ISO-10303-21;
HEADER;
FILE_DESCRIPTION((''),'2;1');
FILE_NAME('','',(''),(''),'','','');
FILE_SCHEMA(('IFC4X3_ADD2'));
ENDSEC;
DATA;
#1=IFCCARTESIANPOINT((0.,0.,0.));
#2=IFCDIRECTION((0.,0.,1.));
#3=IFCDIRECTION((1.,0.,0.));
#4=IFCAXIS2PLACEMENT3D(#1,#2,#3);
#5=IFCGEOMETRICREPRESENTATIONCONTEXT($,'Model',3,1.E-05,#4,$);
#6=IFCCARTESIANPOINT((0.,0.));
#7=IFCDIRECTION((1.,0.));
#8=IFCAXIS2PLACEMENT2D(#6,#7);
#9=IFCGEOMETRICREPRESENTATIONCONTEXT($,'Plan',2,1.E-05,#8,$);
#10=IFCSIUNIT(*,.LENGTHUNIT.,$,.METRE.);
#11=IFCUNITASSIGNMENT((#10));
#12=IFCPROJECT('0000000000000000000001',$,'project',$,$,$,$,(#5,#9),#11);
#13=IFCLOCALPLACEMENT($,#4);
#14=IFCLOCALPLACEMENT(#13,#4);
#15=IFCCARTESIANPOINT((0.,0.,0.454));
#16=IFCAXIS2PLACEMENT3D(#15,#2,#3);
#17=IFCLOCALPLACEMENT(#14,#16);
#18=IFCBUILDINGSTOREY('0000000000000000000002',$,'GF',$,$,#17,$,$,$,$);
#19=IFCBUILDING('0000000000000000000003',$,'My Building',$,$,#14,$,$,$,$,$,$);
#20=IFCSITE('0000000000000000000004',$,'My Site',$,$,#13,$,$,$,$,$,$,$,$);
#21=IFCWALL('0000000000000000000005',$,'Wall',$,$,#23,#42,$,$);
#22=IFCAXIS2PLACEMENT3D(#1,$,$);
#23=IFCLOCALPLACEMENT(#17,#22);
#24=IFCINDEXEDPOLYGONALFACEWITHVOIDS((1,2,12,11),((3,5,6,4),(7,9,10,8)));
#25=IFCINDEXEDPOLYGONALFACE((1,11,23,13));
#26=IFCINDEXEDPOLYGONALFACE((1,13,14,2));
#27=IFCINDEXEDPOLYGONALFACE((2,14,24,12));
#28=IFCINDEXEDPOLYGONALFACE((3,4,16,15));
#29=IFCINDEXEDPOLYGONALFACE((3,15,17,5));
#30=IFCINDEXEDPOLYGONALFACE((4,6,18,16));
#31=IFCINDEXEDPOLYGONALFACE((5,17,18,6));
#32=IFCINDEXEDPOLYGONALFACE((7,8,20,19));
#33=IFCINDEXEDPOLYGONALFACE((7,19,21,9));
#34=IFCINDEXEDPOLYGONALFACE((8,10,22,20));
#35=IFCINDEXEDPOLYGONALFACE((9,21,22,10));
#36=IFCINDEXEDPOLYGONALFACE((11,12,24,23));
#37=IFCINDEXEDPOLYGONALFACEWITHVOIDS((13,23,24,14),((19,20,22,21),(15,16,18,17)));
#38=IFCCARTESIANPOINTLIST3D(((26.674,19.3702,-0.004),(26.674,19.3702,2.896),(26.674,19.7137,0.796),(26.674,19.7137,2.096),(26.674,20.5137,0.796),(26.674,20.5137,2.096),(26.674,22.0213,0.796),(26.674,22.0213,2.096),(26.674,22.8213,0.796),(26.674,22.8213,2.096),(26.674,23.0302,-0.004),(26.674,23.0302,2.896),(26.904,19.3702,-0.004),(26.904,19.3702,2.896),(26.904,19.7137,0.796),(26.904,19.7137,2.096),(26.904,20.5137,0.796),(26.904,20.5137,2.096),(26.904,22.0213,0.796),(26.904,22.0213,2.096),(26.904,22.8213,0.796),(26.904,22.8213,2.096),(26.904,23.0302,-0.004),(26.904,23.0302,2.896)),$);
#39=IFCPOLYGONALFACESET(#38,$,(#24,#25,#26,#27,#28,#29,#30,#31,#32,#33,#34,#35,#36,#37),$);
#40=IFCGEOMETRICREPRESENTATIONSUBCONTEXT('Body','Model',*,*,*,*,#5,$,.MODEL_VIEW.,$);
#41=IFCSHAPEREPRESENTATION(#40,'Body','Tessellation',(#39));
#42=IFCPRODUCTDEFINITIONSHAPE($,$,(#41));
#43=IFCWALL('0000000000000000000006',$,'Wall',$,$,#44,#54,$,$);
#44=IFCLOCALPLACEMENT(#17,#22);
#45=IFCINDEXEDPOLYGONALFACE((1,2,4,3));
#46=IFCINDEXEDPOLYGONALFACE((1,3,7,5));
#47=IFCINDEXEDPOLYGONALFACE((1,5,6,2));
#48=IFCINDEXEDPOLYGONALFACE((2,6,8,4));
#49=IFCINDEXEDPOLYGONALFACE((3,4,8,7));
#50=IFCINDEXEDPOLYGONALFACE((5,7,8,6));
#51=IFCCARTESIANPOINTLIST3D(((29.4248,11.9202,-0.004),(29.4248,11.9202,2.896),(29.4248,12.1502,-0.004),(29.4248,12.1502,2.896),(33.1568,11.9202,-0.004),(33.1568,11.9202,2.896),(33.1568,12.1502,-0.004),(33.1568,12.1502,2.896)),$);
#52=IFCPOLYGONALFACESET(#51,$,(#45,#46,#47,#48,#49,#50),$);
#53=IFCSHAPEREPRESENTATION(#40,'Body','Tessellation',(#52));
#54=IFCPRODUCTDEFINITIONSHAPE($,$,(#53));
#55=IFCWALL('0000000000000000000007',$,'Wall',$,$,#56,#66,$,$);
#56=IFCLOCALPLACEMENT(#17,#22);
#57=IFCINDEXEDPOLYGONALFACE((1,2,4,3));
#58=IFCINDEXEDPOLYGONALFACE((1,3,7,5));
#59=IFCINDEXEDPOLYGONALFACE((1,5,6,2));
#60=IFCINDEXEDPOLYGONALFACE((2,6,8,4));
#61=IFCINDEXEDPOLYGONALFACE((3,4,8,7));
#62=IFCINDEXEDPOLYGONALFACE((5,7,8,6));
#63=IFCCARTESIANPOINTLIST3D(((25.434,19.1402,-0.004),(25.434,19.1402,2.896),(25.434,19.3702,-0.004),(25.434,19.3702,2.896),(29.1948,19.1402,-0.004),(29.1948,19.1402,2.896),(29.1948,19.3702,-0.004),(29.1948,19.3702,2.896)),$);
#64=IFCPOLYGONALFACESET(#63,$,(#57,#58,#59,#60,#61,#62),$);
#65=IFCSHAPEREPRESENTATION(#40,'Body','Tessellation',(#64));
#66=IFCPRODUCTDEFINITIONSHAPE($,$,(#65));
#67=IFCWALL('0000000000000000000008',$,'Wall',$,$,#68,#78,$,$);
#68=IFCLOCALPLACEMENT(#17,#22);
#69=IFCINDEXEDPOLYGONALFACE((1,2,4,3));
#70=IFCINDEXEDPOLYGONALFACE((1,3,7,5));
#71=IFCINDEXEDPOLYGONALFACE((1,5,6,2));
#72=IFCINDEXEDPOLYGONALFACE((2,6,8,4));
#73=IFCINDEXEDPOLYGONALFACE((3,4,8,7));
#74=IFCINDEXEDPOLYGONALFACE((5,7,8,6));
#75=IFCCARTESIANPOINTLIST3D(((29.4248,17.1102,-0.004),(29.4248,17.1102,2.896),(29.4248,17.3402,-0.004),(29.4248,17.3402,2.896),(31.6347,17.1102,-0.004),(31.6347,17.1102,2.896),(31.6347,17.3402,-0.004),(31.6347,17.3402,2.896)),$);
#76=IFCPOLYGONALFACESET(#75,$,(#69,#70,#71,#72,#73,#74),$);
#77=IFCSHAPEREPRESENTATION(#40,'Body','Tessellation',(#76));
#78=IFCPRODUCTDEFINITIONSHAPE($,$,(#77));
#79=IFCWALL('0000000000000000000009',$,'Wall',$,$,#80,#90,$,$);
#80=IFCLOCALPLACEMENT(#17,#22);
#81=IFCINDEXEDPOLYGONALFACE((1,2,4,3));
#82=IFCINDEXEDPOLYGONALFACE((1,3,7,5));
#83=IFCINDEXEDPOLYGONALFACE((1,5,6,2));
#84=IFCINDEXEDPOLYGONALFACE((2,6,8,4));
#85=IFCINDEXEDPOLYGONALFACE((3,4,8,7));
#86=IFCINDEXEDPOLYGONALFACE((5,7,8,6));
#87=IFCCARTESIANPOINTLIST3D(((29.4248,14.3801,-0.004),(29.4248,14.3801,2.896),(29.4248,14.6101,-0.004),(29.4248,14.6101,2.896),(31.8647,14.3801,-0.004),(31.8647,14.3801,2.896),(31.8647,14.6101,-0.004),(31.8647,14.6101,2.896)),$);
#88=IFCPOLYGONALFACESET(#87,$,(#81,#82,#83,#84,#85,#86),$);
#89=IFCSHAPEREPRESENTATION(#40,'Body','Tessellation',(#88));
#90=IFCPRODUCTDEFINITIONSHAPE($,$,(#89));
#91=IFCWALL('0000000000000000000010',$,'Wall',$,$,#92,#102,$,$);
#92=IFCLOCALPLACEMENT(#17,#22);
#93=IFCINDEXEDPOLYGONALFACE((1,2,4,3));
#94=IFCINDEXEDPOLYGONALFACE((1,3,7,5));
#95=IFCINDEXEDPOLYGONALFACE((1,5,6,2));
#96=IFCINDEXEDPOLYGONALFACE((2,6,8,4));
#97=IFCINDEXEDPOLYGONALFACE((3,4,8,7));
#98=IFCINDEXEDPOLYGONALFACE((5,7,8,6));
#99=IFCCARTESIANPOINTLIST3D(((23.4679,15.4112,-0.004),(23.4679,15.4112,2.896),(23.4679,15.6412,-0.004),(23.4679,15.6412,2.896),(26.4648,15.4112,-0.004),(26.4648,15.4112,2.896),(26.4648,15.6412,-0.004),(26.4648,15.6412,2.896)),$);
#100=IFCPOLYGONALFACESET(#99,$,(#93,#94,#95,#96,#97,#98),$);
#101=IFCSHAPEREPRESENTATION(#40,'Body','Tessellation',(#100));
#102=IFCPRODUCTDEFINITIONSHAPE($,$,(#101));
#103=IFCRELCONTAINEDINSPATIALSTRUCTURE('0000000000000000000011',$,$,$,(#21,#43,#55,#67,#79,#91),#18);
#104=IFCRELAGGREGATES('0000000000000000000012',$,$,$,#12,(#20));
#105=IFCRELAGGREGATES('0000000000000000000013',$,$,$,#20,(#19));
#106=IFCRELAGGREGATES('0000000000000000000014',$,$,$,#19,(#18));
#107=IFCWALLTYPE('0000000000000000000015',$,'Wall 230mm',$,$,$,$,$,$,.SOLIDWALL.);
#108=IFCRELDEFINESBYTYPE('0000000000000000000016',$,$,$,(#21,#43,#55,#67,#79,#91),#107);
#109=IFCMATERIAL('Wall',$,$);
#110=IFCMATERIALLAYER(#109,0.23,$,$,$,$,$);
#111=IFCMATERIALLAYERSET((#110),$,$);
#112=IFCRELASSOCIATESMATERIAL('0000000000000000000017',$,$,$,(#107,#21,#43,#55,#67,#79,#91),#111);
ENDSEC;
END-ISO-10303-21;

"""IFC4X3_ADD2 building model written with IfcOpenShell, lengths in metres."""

from ifc_helpers import new_model, si_unit, frame, origin_with_axes, origin_2d_with_axis, place, context, subcontext, project, spatial, line, indexed_curve, outline, extrude, source, transform, mapped, material, layer, layer_set, layer_usage, type_object, element, save


model = new_model("IFC4X3_ADD2")

# Units and contexts
model_context = context("Model", 3, precision=1e-05, world=origin_with_axes())
plan_context = context("Plan", 2, precision=1e-05, world=origin_2d_with_axis())
body_context_1 = subcontext(model_context, "Body", "Model", "MODEL_VIEW")
ifc_project = project(units=[si_unit("LENGTHUNIT", "METRE")], contexts=[model_context, plan_context])

# Site, building, storey
site_placement = place(None, origin_with_axes())
site = spatial("IfcSite", under=ifc_project, at=site_placement, Name="My Site")
building_placement = place(site_placement, origin_with_axes())
building = spatial("IfcBuilding", under=site, at=building_placement, Name="My Building")
storey_placement = place(building_placement, frame((0.0, 0.0, 0.454), z_axis=(0.0, 0.0, 1.0), x_axis=(1.0, 0.0, 0.0)))
storey = spatial("IfcBuildingStorey", under=building, at=storey_placement, Name="GF")

# Shared definitions
ifc_material_1 = material(Name="Wall")

# Shared definitions
ifc_layer_1 = layer(ifc_material_1, 0.23)
ifc_layer_set_1 = layer_set([ifc_layer_1])
wall_type_1 = type_object("IfcWallType", Name="Wall 230mm", PredefinedType="SOLIDWALL", material=ifc_layer_set_1)

# Wall, openings
ifc_layer_usage_1 = layer_usage(ifc_layer_set_1, "AXIS2", "POSITIVE", 0.0)
wall_1_placement = place(storey_placement, frame((26.904, 19.3702, -0.004), z_axis=(0.0, 0.0, 1.0), x_axis=(0.000001, 1.0, 0.0)))
wall_1 = element("IfcWall", 1, at=wall_1_placement, inside=storey, type_object=wall_type_1, material=ifc_layer_usage_1, Name="Wall", context=body_context_1, shape_type="SweptSolid", body=[
    extrude(outline(indexed_curve([(0.0, 0.0), (0.0, 0.23), (3.66, 0.23), (3.66, 0.0), (0.0, 0.0)], self_intersect=False)), origin_with_axes(), (0.0, 0.0, 1.0), 2.9),
])
shared_shape_1 = source(origin_with_axes(), body_context_1, "Body", "SweptSolid", [
    extrude(outline(indexed_curve([(0.0, 0.0), (0.8, 0.0), (0.8, 1.3), (0.0, 1.3)], segments=[line(1, 2, 3, 4, 1)])), frame((-0.4, -0.6, 0.0), z_axis=(0.0, -1.0, 0.0), x_axis=(1.0, 0.0, 0.0)), (0.0, 0.0, -1.0), 1.2),
])
opening_1_placement = place(wall_1_placement, frame((0.7435, 0.0, 0.8), z_axis=(0.0, 0.0, 1.0), x_axis=(1.0, 0.0, 0.0)))
element("IfcOpeningElement", 2, at=opening_1_placement, cuts=wall_1, PredefinedType="OPENING", context=body_context_1, shape_type="MappedRepresentation", body=[
    mapped(shared_shape_1, transform((0.0, 0.0, 0.0), x_axis=(1.0, 0.0, 0.0), y_axis=(0.0, 1.0, 0.0), z_axis=(0.0, 0.0, 1.0), scale=1.0)),
])
opening_2_placement = place(wall_1_placement, frame((3.0511, 0.0, 0.8), z_axis=(0.0, 0.0, 1.0), x_axis=(1.0, 0.0, 0.0)))
element("IfcOpeningElement", 3, at=opening_2_placement, cuts=wall_1, PredefinedType="OPENING", context=body_context_1, shape_type="MappedRepresentation", body=[
    mapped(shared_shape_1, transform((0.0, 0.0, 0.0), x_axis=(1.0, 0.0, 0.0), y_axis=(0.0, 1.0, 0.0), z_axis=(0.0, 0.0, 1.0), scale=1.0)),
])

# Walls
ifc_layer_usage_2 = layer_usage(ifc_layer_set_1, "AXIS2", "POSITIVE", 0.0)
wall_2_placement = place(storey_placement, frame((33.1568, 12.1502, -0.004), z_axis=(0.0, 0.0, 1.0), x_axis=(-1.0, 0.0, 0.0)))
element("IfcWall", 4, at=wall_2_placement, inside=storey, type_object=wall_type_1, material=ifc_layer_usage_2, Name="Wall", context=body_context_1, shape_type="SweptSolid", body=[
    extrude(outline(indexed_curve([(0.0, 0.0), (0.0, 0.23), (3.732, 0.23), (3.732, 0.0), (0.0, 0.0)], self_intersect=False)), origin_with_axes(), (0.0, 0.0, 1.0), 2.9),
])
ifc_layer_usage_3 = layer_usage(ifc_layer_set_1, "AXIS2", "POSITIVE", 0.0)
wall_3_placement = place(storey_placement, frame((29.1948, 19.3702, -0.004), z_axis=(0.0, 0.0, 1.0), x_axis=(-1.0, 0.0, 0.0)))
element("IfcWall", 5, at=wall_3_placement, inside=storey, type_object=wall_type_1, material=ifc_layer_usage_3, Name="Wall", context=body_context_1, shape_type="SweptSolid", body=[
    extrude(outline(indexed_curve([(0.0, 0.0), (0.0, 0.23), (3.7608, 0.23), (3.7608, 0.0), (0.0, 0.0)], self_intersect=False)), origin_with_axes(), (0.0, 0.0, 1.0), 2.9),
])
ifc_layer_usage_4 = layer_usage(ifc_layer_set_1, "AXIS2", "POSITIVE", 0.0)
wall_4_placement = place(storey_placement, frame((31.6347, 17.3402, -0.004), z_axis=(0.0, 0.0, 1.0), x_axis=(-1.0, 0.0, 0.0)))
element("IfcWall", 6, at=wall_4_placement, inside=storey, type_object=wall_type_1, material=ifc_layer_usage_4, Name="Wall", context=body_context_1, shape_type="SweptSolid", body=[
    extrude(outline(indexed_curve([(0.0, 0.0), (0.0, 0.23), (2.21, 0.23), (2.21, 0.0), (0.0, 0.0)], self_intersect=False)), origin_with_axes(), (0.0, 0.0, 1.0), 2.9),
])
ifc_layer_usage_5 = layer_usage(ifc_layer_set_1, "AXIS2", "POSITIVE", 0.0)
wall_5_placement = place(storey_placement, frame((31.8647, 14.6101, -0.004), z_axis=(0.0, 0.0, 1.0), x_axis=(-1.0, 0.0, 0.0)))
element("IfcWall", 7, at=wall_5_placement, inside=storey, type_object=wall_type_1, material=ifc_layer_usage_5, Name="Wall", context=body_context_1, shape_type="SweptSolid", body=[
    extrude(outline(indexed_curve([(0.0, 0.0), (0.0, 0.23), (2.44, 0.23), (2.44, 0.0), (0.0, 0.0)], self_intersect=False)), origin_with_axes(), (0.0, 0.0, 1.0), 2.9),
])
ifc_layer_usage_6 = layer_usage(ifc_layer_set_1, "AXIS2", "POSITIVE", 0.0)
wall_6_placement = place(storey_placement, frame((26.4648, 15.6412, -0.004), z_axis=(0.0, 0.0, 1.0), x_axis=(-1.0, 0.0, 0.0)))
element("IfcWall", 8, at=wall_6_placement, inside=storey, type_object=wall_type_1, material=ifc_layer_usage_6, Name="Wall", context=body_context_1, shape_type="SweptSolid", body=[
    extrude(outline(indexed_curve([(0.0, 0.0), (0.0, 0.23), (2.9969, 0.23), (2.9969, 0.0), (0.0, 0.0)], self_intersect=False)), origin_with_axes(), (0.0, 0.0, 1.0), 2.9),
])

save(model, "model.ifc")
